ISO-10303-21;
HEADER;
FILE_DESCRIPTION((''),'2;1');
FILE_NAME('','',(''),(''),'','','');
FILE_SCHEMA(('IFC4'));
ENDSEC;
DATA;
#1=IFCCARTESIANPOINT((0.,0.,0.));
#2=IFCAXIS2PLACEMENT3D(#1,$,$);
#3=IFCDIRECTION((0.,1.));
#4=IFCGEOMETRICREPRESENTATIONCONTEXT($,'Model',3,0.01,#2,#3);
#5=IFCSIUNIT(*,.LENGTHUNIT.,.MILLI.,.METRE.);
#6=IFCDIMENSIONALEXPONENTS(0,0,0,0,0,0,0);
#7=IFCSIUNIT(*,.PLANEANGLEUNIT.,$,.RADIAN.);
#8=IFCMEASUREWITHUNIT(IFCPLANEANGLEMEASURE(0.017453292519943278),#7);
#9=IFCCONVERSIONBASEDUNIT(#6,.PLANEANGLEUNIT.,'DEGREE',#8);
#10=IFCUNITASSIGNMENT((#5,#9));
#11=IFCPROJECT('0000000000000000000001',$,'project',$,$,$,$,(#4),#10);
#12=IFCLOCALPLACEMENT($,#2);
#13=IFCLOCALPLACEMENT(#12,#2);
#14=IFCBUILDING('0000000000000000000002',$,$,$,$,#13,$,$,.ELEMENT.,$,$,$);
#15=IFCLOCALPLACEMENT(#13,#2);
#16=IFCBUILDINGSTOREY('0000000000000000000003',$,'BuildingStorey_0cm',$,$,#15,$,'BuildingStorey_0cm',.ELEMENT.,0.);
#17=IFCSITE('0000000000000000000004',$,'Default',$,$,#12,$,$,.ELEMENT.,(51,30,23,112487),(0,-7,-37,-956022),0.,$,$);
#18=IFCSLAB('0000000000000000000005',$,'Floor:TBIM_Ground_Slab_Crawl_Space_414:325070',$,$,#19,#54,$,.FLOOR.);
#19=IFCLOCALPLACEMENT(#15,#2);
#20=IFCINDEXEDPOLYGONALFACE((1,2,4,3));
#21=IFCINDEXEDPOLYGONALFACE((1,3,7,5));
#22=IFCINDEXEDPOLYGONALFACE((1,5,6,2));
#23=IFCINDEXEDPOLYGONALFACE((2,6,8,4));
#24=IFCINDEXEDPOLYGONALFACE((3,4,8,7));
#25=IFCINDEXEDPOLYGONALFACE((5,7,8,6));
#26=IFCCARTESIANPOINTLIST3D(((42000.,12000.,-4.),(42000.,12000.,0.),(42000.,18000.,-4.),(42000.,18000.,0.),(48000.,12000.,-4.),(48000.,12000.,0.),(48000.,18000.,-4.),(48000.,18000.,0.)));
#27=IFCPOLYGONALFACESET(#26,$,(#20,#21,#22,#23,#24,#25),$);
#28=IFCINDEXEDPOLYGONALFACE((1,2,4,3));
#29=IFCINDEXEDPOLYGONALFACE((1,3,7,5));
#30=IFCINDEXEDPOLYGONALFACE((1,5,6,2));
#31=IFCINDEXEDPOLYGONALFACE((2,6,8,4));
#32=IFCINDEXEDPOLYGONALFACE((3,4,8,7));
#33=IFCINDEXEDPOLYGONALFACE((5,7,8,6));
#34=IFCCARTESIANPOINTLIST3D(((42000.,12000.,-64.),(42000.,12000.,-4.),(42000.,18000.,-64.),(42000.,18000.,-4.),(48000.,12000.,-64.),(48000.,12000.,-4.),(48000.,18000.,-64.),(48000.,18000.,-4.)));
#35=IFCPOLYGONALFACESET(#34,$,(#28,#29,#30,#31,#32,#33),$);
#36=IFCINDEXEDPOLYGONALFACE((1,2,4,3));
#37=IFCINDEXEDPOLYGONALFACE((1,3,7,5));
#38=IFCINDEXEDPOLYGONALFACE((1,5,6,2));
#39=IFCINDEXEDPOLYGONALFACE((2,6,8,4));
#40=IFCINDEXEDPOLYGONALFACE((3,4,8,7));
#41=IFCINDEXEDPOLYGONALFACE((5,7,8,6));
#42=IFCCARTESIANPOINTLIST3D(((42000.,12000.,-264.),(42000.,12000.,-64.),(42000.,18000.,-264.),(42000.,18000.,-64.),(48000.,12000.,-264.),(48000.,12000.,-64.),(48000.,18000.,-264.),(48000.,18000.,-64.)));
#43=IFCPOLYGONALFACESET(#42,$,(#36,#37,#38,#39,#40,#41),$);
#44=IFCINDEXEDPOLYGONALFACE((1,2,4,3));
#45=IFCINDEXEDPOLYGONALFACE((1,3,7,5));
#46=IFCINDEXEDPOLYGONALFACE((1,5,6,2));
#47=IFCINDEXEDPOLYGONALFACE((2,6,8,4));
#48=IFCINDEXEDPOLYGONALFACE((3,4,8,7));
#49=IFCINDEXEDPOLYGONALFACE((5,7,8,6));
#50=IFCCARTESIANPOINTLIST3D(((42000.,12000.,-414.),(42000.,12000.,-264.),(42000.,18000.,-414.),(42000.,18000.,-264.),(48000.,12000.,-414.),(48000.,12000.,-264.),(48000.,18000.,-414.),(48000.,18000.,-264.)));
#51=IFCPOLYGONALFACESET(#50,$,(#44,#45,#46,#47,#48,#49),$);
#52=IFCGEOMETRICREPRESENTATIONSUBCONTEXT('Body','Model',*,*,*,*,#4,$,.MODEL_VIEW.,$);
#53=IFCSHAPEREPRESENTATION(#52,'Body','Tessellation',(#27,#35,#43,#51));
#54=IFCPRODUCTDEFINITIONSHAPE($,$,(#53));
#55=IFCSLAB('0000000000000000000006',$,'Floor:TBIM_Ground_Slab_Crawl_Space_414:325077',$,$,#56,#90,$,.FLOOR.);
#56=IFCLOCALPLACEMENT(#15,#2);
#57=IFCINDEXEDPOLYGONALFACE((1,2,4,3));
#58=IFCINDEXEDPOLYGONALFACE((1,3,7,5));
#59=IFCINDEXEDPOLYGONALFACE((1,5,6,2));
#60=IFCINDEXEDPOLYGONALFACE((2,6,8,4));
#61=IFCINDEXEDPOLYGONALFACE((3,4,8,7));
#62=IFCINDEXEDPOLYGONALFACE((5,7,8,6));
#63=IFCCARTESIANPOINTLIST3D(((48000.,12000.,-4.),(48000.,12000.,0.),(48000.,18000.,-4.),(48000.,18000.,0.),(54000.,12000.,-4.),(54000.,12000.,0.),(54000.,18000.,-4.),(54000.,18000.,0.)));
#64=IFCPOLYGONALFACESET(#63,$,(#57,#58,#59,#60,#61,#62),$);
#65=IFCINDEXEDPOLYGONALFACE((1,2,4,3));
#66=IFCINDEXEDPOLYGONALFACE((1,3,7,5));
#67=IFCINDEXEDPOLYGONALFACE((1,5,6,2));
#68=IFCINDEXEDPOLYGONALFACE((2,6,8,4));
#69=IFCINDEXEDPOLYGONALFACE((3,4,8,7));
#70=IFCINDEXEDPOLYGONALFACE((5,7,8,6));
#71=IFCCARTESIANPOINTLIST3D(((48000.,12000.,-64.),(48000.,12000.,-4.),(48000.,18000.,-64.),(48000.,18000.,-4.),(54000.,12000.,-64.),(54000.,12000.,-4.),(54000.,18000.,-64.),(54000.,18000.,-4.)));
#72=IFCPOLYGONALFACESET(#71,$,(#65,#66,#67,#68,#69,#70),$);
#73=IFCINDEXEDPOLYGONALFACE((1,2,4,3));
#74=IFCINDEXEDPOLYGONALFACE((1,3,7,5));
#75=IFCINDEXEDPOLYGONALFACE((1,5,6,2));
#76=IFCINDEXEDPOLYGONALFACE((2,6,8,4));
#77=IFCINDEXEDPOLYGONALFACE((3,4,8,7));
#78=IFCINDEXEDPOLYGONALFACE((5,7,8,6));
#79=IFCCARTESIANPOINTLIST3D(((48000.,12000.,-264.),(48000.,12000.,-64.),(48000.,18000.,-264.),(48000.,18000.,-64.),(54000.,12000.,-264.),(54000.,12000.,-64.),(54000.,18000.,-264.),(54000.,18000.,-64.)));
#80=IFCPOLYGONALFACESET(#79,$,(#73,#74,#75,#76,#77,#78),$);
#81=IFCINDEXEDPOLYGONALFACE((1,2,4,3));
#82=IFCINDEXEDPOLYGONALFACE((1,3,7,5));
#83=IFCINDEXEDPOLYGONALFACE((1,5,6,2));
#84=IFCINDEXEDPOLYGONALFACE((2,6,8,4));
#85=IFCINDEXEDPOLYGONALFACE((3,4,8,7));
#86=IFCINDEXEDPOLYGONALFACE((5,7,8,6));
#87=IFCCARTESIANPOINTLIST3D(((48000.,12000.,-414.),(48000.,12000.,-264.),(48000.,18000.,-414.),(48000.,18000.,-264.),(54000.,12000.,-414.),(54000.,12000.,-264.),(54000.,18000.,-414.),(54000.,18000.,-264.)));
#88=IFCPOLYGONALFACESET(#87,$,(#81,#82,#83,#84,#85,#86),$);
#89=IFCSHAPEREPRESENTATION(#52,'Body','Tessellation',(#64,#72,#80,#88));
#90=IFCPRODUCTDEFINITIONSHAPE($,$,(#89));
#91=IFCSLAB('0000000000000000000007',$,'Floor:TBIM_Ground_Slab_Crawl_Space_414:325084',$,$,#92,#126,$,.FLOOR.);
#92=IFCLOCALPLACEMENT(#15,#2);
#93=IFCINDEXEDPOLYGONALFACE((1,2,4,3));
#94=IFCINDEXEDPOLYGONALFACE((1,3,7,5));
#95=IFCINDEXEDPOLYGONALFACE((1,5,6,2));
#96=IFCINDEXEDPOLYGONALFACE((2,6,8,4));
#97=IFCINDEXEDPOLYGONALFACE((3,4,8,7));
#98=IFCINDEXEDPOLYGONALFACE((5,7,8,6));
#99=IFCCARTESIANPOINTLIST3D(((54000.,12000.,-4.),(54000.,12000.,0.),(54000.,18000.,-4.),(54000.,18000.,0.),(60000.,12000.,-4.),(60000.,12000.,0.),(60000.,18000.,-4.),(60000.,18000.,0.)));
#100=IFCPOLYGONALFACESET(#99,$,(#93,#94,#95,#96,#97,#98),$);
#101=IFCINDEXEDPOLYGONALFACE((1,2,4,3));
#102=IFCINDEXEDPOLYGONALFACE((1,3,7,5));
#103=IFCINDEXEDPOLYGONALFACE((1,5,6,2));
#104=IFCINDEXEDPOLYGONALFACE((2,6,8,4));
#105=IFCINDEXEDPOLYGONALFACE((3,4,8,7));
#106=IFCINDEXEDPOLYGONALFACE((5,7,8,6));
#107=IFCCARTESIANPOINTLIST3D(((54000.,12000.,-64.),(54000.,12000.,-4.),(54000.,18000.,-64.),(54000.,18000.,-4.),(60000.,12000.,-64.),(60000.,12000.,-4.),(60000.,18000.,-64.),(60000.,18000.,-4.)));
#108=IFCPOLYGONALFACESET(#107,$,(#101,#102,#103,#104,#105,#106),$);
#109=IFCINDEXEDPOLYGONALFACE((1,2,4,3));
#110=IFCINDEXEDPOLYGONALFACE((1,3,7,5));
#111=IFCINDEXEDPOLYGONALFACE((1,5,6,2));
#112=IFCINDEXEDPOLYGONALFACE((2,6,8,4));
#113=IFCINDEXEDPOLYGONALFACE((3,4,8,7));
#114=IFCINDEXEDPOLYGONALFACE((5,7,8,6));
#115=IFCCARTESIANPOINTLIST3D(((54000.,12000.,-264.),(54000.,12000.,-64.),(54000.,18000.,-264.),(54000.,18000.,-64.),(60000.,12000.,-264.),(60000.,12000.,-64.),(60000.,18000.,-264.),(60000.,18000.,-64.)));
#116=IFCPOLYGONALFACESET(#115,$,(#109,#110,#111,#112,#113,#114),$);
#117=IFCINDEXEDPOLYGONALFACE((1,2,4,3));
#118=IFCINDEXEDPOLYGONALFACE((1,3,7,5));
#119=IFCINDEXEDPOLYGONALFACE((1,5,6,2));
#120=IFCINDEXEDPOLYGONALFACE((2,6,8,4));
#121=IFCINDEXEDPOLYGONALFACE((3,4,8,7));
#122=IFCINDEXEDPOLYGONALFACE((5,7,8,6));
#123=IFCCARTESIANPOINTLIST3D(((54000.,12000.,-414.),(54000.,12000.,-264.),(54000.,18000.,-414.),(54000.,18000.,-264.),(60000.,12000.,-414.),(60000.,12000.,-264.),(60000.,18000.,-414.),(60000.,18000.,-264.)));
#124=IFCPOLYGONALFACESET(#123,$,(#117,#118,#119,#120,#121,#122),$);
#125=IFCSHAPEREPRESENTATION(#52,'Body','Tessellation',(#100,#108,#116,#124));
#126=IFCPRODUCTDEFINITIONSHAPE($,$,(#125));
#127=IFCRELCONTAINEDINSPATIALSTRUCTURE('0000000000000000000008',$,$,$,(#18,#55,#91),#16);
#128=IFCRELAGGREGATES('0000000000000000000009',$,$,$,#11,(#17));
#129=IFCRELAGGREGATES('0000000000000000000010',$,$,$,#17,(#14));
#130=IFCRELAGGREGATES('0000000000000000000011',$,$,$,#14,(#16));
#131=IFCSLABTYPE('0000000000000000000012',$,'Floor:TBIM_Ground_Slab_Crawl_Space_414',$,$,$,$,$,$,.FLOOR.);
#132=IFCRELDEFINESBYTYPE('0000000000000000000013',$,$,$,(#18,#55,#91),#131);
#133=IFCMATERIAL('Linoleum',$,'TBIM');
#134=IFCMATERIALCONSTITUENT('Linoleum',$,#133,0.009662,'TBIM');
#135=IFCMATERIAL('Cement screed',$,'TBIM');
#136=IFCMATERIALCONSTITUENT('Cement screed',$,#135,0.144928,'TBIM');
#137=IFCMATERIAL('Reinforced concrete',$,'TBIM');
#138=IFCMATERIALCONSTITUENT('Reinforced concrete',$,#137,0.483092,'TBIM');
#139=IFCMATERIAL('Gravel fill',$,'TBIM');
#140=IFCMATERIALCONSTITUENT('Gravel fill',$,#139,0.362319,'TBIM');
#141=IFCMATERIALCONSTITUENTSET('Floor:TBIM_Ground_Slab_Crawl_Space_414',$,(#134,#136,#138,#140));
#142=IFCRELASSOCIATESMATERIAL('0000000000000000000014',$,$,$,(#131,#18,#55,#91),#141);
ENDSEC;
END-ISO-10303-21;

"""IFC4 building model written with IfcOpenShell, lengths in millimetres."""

from ifc_helpers import new_model, entity, si_unit, converted_unit, direction, frame, origin, place, context, subcontext, project, spatial, indexed_curve, outline, extrude, material, constituent, constituent_set, type_object, element, save


model = new_model("IFC4")

# Units and contexts
model_context = context("Model", 3, precision=0.01, world=origin(), true_north=direction((0.0, 1.0)))
body_context = subcontext(model_context, "Body", "Model", "MODEL_VIEW")
ifc_project = project(units=[si_unit("LENGTHUNIT", "METRE", prefix="MILLI"), converted_unit("PLANEANGLEUNIT", "DEGREE", entity("IfcPlaneAngleMeasure", 0.017453292519943278), si_unit("PLANEANGLEUNIT", "RADIAN"), dimensions=[0, 0, 0, 0, 0, 0, 0])], contexts=[model_context])

# Site, building, storey
site_placement = place(None, origin())
site = spatial("IfcSite", under=ifc_project, at=site_placement, Name="Default", CompositionType="ELEMENT", RefLatitude=(51, 30, 23, 112487), RefLongitude=(0, -7, -37, -956022), RefElevation=0.0)
building_placement = place(site_placement, origin())
building = spatial("IfcBuilding", under=site, at=building_placement, CompositionType="ELEMENT")
storey_placement = place(building_placement, origin())
storey = spatial("IfcBuildingStorey", under=building, at=storey_placement, Name="BuildingStorey_0cm", LongName="BuildingStorey_0cm", CompositionType="ELEMENT", Elevation=0.0)

# Slabs
ifc_material_1 = material(Name="Linoleum", Category="TBIM")
ifc_constituent_1 = constituent(ifc_material_1, Name="Linoleum", Category="TBIM", fraction=0.009662)
ifc_material_2 = material(Name="Cement screed", Category="TBIM")
ifc_constituent_2 = constituent(ifc_material_2, Name="Cement screed", Category="TBIM", fraction=0.144928)
ifc_material_3 = material(Name="Reinforced concrete", Category="TBIM")
ifc_constituent_3 = constituent(ifc_material_3, Name="Reinforced concrete", Category="TBIM", fraction=0.483092)
ifc_material_4 = material(Name="Gravel fill", Category="TBIM")
ifc_constituent_4 = constituent(ifc_material_4, Name="Gravel fill", Category="TBIM", fraction=0.362319)
ifc_constituent_set_1 = constituent_set(constituents=[ifc_constituent_1, ifc_constituent_2, ifc_constituent_3, ifc_constituent_4], Name="Floor:TBIM_Ground_Slab_Crawl_Space_414")
slab_type = type_object("IfcSlabType", Name="Floor:TBIM_Ground_Slab_Crawl_Space_414", PredefinedType="FLOOR", material=ifc_constituent_set_1)
slab_1_placement = place(storey_placement, origin())
element("IfcSlab", 1, at=slab_1_placement, inside=storey, type_object=slab_type, material=ifc_constituent_set_1, Name="Floor:TBIM_Ground_Slab_Crawl_Space_414:325070", PredefinedType="FLOOR", context=body_context, shape_type="SweptSolid", body=[
    extrude(outline(indexed_curve([(-3000.0, -3000.0), (3000.0, -3000.0), (3000.0, 3000.0), (-3000.0, 3000.0), (-3000.0, -3000.0)], self_intersect=False)), frame((45000.0, 15000.0, -4.0), z_axis=(0.0, 0.0, 1.0), x_axis=(-1.0, 0.0, 0.0)), (0.0, 0.0, 1.0), 4.0),
    extrude(outline(indexed_curve([(-3000.0, -3000.0), (3000.0, -3000.0), (3000.0, 3000.0), (-3000.0, 3000.0), (-3000.0, -3000.0)], self_intersect=False)), frame((45000.0, 15000.0, -64.0), z_axis=(0.0, 0.0, 1.0), x_axis=(-1.0, 0.0, 0.0)), (0.0, 0.0, 1.0), 60.0),
    extrude(outline(indexed_curve([(-3000.0, -3000.0), (3000.0, -3000.0), (3000.0, 3000.0), (-3000.0, 3000.0), (-3000.0, -3000.0)], self_intersect=False)), frame((45000.0, 15000.0, -264.0), z_axis=(0.0, 0.0, 1.0), x_axis=(-1.0, 0.0, 0.0)), (0.0, 0.0, 1.0), 200.0),
    extrude(outline(indexed_curve([(-3000.0, -3000.0), (3000.0, -3000.0), (3000.0, 3000.0), (-3000.0, 3000.0), (-3000.0, -3000.0)], self_intersect=False)), frame((45000.0, 15000.0, -414.0), z_axis=(0.0, 0.0, 1.0), x_axis=(-1.0, 0.0, 0.0)), (0.0, 0.0, 1.0), 150.0),
])
slab_2_placement = place(storey_placement, origin())
element("IfcSlab", 2, at=slab_2_placement, inside=storey, type_object=slab_type, material=ifc_constituent_set_1, Name="Floor:TBIM_Ground_Slab_Crawl_Space_414:325077", PredefinedType="FLOOR", context=body_context, shape_type="SweptSolid", body=[
    extrude(outline(indexed_curve([(-3000.0, -3000.0), (3000.0, -3000.0), (3000.0, 3000.0), (-3000.0, 3000.0), (-3000.0, -3000.0)], self_intersect=False)), frame((51000.0, 15000.0, -4.0), z_axis=(0.0, 0.0, 1.0), x_axis=(-1.0, 0.0, 0.0)), (0.0, 0.0, 1.0), 4.0),
    extrude(outline(indexed_curve([(-3000.0, -3000.0), (3000.0, -3000.0), (3000.0, 3000.0), (-3000.0, 3000.0), (-3000.0, -3000.0)], self_intersect=False)), frame((51000.0, 15000.0, -64.0), z_axis=(0.0, 0.0, 1.0), x_axis=(-1.0, 0.0, 0.0)), (0.0, 0.0, 1.0), 60.0),
    extrude(outline(indexed_curve([(-3000.0, -3000.0), (3000.0, -3000.0), (3000.0, 3000.0), (-3000.0, 3000.0), (-3000.0, -3000.0)], self_intersect=False)), frame((51000.0, 15000.0, -264.0), z_axis=(0.0, 0.0, 1.0), x_axis=(-1.0, 0.0, 0.0)), (0.0, 0.0, 1.0), 200.0),
    extrude(outline(indexed_curve([(-3000.0, -3000.0), (3000.0, -3000.0), (3000.0, 3000.0), (-3000.0, 3000.0), (-3000.0, -3000.0)], self_intersect=False)), frame((51000.0, 15000.0, -414.0), z_axis=(0.0, 0.0, 1.0), x_axis=(-1.0, 0.0, 0.0)), (0.0, 0.0, 1.0), 150.0),
])
slab_3_placement = place(storey_placement, origin())
element("IfcSlab", 3, at=slab_3_placement, inside=storey, type_object=slab_type, material=ifc_constituent_set_1, Name="Floor:TBIM_Ground_Slab_Crawl_Space_414:325084", PredefinedType="FLOOR", context=body_context, shape_type="SweptSolid", body=[
    extrude(outline(indexed_curve([(-3000.0, -3000.0), (3000.0, -3000.0), (3000.0, 3000.0), (-3000.0, 3000.0), (-3000.0, -3000.0)], self_intersect=False)), frame((57000.0, 15000.0, -4.0), z_axis=(0.0, 0.0, 1.0), x_axis=(-1.0, 0.0, 0.0)), (0.0, 0.0, 1.0), 4.0),
    extrude(outline(indexed_curve([(-3000.0, -3000.0), (3000.0, -3000.0), (3000.0, 3000.0), (-3000.0, 3000.0), (-3000.0, -3000.0)], self_intersect=False)), frame((57000.0, 15000.0, -64.0), z_axis=(0.0, 0.0, 1.0), x_axis=(-1.0, 0.0, 0.0)), (0.0, 0.0, 1.0), 60.0),
    extrude(outline(indexed_curve([(-3000.0, -3000.0), (3000.0, -3000.0), (3000.0, 3000.0), (-3000.0, 3000.0), (-3000.0, -3000.0)], self_intersect=False)), frame((57000.0, 15000.0, -264.0), z_axis=(0.0, 0.0, 1.0), x_axis=(-1.0, 0.0, 0.0)), (0.0, 0.0, 1.0), 200.0),
    extrude(outline(indexed_curve([(-3000.0, -3000.0), (3000.0, -3000.0), (3000.0, 3000.0), (-3000.0, 3000.0), (-3000.0, -3000.0)], self_intersect=False)), frame((57000.0, 15000.0, -414.0), z_axis=(0.0, 0.0, 1.0), x_axis=(-1.0, 0.0, 0.0)), (0.0, 0.0, 1.0), 150.0),
])

save(model, "model.ifc")
